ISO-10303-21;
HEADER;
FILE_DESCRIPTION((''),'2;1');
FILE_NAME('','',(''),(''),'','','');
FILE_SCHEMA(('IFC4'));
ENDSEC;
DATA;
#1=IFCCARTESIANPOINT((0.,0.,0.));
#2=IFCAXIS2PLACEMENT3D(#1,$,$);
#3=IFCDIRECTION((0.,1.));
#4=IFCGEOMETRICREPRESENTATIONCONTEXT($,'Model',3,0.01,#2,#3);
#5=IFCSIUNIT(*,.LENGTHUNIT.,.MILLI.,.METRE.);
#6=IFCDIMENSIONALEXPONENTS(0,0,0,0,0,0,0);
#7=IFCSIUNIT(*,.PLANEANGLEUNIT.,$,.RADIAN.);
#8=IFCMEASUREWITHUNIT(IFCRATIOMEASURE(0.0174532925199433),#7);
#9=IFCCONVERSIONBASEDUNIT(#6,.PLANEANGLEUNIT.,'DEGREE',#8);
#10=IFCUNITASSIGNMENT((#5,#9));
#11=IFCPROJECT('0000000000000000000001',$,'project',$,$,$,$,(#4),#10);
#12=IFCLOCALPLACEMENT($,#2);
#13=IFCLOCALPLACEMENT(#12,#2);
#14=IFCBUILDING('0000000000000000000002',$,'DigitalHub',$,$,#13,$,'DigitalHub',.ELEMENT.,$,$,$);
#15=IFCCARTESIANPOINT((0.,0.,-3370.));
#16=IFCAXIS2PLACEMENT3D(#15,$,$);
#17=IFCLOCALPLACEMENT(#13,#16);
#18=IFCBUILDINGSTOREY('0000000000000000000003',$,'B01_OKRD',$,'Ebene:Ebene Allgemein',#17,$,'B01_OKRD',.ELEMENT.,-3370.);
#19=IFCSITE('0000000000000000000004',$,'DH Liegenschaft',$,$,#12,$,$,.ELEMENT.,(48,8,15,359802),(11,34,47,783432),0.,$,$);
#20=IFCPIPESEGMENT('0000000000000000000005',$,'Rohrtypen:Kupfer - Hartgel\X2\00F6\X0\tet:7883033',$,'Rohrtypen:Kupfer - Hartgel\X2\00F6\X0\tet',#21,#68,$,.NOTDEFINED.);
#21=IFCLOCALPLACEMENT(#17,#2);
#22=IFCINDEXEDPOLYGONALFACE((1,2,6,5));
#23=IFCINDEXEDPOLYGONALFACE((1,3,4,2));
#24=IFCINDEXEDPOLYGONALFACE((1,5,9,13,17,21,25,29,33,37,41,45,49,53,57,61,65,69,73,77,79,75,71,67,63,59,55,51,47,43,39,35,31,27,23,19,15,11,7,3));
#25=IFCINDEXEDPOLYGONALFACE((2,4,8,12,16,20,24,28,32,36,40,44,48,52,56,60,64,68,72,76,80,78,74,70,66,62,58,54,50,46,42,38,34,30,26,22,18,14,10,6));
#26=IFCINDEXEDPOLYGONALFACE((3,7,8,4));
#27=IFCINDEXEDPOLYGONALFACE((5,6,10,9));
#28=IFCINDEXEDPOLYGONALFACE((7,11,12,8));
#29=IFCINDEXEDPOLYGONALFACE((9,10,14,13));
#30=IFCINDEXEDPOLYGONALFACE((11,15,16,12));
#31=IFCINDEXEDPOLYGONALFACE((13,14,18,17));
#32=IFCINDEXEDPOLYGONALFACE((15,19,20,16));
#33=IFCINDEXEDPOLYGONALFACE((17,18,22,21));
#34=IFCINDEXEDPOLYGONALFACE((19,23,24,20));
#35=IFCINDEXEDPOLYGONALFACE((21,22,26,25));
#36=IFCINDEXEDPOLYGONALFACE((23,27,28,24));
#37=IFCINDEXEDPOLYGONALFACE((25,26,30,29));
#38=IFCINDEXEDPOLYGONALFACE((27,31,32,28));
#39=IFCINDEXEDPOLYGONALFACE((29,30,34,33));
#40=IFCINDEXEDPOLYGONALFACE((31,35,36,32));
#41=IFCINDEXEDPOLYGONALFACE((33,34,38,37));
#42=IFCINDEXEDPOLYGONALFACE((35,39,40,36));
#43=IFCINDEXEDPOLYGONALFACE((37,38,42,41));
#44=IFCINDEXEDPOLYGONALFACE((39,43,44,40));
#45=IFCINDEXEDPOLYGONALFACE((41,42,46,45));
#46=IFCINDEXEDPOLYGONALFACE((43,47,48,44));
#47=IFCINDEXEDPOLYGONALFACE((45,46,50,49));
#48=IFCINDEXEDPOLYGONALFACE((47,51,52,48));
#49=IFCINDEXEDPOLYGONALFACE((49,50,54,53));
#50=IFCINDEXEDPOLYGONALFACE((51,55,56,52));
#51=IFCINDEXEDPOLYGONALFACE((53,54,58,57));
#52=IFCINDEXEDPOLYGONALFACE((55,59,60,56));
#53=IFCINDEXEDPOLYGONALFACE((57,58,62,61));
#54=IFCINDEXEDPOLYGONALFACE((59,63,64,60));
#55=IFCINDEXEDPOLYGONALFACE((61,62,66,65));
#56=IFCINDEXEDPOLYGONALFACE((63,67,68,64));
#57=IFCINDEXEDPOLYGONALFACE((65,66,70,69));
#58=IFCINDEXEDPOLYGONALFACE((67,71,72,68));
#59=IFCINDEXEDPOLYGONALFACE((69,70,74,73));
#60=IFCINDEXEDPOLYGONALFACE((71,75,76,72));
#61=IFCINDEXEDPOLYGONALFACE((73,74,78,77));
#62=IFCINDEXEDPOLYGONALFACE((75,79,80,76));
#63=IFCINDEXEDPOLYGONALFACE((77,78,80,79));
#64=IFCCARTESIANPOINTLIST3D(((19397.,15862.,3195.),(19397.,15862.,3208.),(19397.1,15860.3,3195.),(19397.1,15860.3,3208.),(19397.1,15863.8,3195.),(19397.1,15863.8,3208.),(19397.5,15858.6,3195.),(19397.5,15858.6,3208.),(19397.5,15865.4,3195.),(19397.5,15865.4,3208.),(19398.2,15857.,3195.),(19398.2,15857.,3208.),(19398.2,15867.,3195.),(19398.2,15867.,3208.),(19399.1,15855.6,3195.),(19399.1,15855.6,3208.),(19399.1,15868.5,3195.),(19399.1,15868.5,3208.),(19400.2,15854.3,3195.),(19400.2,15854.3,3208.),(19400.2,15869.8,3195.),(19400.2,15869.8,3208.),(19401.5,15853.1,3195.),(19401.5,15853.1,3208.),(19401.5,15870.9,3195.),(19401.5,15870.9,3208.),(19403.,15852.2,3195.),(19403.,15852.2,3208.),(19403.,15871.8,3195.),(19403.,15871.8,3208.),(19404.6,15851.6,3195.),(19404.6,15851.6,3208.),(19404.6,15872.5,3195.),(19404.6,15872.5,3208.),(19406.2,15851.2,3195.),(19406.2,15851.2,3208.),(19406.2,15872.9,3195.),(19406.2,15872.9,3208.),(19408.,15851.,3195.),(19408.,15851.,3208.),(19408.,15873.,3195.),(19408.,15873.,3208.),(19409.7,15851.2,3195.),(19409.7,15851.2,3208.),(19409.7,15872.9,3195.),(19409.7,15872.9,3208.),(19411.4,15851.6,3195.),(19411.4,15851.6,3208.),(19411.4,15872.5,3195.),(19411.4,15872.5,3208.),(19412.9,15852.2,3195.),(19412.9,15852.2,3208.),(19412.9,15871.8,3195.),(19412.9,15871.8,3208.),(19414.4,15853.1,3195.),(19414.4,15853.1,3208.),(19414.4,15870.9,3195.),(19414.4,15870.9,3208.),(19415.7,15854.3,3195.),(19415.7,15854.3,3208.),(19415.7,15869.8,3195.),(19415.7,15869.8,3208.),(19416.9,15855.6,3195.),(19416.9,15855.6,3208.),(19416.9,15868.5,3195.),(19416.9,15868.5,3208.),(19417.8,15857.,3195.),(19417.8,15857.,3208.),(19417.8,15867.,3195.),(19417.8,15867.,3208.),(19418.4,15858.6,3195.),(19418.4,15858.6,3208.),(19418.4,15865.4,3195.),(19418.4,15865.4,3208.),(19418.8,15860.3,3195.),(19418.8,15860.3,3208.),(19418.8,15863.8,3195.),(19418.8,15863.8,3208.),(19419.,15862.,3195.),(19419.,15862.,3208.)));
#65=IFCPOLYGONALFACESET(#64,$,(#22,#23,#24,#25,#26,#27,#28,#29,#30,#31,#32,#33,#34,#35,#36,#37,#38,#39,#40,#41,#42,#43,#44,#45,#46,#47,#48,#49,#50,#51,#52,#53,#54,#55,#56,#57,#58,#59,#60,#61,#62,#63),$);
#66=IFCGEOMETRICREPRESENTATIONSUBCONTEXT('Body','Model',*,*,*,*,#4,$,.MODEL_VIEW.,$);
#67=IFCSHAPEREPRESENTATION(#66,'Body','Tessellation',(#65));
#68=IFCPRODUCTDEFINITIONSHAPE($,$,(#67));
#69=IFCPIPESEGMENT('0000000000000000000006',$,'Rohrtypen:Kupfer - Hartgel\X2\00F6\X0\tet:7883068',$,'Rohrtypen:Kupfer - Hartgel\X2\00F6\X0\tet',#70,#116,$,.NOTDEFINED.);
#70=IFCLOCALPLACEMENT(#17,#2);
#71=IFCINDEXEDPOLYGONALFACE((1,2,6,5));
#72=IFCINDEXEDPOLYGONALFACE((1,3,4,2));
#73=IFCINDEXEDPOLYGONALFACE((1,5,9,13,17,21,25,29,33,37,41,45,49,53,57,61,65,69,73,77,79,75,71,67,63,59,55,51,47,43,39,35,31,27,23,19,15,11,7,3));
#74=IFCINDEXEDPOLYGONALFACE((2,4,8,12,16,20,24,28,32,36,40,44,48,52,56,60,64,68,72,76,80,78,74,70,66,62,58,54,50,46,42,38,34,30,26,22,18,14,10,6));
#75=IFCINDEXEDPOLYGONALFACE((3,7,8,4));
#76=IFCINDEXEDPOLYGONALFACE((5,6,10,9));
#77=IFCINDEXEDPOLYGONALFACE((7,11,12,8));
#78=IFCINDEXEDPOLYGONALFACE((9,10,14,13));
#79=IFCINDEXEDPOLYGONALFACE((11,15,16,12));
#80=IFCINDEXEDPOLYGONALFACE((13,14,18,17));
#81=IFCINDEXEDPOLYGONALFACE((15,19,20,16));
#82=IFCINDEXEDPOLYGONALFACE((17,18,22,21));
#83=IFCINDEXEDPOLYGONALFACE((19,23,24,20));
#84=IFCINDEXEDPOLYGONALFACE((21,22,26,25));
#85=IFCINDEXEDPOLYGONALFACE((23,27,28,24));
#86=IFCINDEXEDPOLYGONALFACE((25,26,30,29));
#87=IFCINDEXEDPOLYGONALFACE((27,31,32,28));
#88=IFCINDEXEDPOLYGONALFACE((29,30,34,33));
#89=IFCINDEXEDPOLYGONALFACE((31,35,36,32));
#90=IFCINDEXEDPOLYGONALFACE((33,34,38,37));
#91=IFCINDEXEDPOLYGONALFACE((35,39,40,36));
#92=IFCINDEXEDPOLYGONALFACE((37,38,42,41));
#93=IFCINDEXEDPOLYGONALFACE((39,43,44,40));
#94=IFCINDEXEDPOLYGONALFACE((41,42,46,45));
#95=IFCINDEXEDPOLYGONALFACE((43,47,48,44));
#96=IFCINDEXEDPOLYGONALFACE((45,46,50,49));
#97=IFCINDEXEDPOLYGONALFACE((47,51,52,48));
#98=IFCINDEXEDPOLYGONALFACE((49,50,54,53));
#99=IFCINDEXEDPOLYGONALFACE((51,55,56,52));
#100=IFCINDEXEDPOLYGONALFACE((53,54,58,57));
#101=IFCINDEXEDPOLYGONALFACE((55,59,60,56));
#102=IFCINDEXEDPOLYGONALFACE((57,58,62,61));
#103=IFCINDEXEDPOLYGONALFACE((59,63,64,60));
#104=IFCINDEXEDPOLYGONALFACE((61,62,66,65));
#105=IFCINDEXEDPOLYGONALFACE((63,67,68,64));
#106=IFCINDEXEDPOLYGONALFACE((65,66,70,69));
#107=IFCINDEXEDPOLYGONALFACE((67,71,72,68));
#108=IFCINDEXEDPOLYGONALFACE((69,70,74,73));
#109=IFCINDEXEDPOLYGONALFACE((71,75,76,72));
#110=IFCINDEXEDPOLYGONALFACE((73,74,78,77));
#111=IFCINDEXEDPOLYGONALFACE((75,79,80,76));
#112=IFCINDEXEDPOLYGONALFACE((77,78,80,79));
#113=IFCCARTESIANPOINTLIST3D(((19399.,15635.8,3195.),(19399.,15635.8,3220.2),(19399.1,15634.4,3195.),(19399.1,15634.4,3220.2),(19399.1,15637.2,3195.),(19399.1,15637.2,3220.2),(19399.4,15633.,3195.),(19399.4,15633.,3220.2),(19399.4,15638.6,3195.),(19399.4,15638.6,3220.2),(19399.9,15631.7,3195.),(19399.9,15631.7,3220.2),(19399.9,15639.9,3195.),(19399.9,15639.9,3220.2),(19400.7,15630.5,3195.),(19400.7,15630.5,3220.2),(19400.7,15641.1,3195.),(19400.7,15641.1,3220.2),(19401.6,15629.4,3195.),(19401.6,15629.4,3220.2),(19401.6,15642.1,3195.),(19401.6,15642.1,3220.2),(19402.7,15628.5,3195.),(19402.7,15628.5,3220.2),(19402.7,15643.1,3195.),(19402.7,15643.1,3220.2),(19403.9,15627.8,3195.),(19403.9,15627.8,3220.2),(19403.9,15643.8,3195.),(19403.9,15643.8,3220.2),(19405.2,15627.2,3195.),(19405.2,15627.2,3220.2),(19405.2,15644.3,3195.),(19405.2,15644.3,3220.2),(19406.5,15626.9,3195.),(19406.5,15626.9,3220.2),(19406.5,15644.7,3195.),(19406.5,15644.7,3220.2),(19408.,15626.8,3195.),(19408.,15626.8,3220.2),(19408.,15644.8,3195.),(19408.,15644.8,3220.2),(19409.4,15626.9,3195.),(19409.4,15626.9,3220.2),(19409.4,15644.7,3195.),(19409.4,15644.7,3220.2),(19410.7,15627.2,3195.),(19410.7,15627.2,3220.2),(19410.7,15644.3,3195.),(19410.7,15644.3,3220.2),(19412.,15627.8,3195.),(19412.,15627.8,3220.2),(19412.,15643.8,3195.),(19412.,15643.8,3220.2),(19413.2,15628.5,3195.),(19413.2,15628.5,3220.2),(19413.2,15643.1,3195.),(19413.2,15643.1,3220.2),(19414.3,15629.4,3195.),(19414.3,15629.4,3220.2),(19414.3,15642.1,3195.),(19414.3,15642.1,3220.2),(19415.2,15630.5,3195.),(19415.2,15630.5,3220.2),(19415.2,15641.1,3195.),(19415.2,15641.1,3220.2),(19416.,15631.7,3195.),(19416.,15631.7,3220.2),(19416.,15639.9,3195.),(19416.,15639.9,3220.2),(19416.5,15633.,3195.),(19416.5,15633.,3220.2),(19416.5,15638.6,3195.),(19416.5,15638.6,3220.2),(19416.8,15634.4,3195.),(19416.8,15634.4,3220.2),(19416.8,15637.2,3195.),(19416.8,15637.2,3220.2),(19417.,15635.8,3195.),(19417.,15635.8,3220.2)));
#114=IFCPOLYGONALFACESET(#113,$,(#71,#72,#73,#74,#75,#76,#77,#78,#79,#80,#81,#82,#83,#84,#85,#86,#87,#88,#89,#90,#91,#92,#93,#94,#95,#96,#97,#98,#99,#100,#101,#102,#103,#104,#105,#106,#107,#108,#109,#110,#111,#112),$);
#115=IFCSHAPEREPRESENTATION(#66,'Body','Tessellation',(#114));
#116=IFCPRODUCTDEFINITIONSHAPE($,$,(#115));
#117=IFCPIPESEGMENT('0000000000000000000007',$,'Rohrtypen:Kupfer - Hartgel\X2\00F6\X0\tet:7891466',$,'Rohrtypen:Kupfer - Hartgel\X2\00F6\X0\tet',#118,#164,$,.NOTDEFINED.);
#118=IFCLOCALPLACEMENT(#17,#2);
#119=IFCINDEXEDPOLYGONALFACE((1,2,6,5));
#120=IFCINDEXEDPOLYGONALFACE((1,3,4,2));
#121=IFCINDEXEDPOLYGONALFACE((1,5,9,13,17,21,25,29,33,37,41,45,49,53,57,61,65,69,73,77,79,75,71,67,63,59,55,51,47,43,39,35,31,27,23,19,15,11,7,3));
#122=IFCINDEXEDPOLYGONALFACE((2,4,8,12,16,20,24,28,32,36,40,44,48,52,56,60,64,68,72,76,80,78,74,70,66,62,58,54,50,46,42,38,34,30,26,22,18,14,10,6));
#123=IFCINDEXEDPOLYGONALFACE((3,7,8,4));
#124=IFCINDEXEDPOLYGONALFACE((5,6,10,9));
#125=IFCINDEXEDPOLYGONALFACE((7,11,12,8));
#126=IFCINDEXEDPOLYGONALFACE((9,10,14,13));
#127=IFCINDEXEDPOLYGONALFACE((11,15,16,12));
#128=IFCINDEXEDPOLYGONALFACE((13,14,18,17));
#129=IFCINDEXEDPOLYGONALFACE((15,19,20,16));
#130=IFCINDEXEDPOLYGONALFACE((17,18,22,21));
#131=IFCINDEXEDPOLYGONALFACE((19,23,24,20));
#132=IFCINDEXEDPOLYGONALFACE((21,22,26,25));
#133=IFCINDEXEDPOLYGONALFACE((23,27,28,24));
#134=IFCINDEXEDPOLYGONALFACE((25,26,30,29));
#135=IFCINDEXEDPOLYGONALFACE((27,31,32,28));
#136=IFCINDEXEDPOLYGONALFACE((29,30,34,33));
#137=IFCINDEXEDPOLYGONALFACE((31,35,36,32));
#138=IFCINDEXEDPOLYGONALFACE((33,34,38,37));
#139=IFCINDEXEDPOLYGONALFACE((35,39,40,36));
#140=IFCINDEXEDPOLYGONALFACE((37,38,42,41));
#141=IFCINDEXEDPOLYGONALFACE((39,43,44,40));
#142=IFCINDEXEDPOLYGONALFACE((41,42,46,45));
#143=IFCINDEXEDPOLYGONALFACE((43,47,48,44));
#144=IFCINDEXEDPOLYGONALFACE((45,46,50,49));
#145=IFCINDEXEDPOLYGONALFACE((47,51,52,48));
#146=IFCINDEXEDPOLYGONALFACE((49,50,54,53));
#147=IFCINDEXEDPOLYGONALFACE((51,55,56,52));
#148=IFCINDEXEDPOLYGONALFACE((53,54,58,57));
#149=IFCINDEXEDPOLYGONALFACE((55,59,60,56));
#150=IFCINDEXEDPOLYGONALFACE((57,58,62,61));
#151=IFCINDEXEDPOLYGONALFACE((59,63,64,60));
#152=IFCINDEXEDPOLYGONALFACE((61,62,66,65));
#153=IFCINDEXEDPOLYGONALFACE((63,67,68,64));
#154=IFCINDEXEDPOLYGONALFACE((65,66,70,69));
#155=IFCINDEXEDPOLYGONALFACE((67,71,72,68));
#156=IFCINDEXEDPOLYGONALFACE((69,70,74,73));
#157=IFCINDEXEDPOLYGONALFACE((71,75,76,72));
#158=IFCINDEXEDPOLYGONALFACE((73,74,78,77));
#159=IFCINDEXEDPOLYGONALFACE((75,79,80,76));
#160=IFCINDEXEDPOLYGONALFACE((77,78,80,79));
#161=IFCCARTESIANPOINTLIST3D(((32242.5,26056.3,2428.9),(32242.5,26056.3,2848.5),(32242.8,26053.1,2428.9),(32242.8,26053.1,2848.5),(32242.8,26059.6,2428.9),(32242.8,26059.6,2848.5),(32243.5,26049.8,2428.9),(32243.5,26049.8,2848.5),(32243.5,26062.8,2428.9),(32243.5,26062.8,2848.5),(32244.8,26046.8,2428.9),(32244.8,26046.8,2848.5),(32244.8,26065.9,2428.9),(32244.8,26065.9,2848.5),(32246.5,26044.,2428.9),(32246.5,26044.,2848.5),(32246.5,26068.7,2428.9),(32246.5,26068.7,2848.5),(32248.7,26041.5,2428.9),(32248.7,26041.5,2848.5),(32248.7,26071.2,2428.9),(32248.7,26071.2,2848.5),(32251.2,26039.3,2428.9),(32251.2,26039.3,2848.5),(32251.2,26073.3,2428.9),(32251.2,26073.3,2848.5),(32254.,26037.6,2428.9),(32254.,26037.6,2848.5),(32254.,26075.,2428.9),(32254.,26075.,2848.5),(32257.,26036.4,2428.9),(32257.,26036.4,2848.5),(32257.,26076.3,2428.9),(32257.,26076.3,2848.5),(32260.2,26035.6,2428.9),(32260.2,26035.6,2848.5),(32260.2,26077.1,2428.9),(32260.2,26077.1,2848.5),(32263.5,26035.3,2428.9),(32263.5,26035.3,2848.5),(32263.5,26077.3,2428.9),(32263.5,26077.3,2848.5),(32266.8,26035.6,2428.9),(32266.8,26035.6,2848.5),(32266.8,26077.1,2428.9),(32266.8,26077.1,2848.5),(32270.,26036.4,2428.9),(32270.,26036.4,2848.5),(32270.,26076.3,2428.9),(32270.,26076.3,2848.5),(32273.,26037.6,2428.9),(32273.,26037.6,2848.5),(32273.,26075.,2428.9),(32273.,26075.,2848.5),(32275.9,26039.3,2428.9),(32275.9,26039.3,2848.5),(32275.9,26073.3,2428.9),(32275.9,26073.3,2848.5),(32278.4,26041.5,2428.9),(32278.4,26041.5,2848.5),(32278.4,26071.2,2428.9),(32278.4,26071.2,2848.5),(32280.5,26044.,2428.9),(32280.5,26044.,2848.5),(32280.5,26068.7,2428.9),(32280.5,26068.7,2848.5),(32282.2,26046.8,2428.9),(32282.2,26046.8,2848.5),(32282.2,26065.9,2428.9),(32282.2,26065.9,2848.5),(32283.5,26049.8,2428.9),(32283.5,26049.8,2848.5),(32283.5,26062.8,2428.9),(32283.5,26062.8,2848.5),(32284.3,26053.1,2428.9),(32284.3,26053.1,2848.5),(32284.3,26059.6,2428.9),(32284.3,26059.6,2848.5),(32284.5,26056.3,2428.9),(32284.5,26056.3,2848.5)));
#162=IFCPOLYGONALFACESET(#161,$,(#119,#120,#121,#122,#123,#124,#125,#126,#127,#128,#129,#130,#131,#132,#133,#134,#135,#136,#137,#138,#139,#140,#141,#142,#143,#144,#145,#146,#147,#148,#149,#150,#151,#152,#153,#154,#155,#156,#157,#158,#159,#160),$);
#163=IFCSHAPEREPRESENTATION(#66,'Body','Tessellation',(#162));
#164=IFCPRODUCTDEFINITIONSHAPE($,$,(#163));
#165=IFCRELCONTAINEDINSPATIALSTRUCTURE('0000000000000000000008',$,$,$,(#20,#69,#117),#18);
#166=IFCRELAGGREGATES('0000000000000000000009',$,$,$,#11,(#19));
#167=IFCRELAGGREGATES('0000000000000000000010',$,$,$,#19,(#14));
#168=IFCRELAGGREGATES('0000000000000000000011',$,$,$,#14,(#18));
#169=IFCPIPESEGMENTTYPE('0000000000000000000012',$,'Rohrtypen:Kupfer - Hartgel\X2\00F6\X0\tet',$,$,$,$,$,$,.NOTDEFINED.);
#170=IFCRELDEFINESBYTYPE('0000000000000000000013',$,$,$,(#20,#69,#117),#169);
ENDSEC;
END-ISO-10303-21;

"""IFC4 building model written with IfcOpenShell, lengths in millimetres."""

from ifc_helpers import new_model, entity, si_unit, converted_unit, direction, frame, origin, place, context, subcontext, project, spatial, indexed_curve, outline, extrude, type_object, element, save


model = new_model("IFC4")

# Units and contexts
model_context = context("Model", 3, precision=0.01, world=origin(), true_north=direction((0.0, 1.0)))
body_context = subcontext(model_context, "Body", "Model", "MODEL_VIEW")
ifc_project = project(units=[si_unit("LENGTHUNIT", "METRE", prefix="MILLI"), converted_unit("PLANEANGLEUNIT", "DEGREE", entity("IfcRatioMeasure", 0.0174532925199433), si_unit("PLANEANGLEUNIT", "RADIAN"), dimensions=[0, 0, 0, 0, 0, 0, 0])], contexts=[model_context])

# Site, building, storey
site_placement = place(None, origin())
site = spatial("IfcSite", under=ifc_project, at=site_placement, Name="DH Liegenschaft", CompositionType="ELEMENT", RefLatitude=(48, 8, 15, 359802), RefLongitude=(11, 34, 47, 783432), RefElevation=0.0)
building_placement = place(site_placement, origin())
building = spatial("IfcBuilding", under=site, at=building_placement, Name="DigitalHub", LongName="DigitalHub", CompositionType="ELEMENT")
storey_placement = place(building_placement, frame((0.0, 0.0, -3370.0)))
storey = spatial("IfcBuildingStorey", under=building, at=storey_placement, Name="B01_OKRD", ObjectType="Ebene:Ebene Allgemein", LongName="B01_OKRD", CompositionType="ELEMENT", Elevation=-3370.0)

# Pipe segments
pipe_segment_type = type_object("IfcPipeSegmentType", Name="Rohrtypen:Kupfer - Hartgelötet", PredefinedType="NOTDEFINED")
pipe_segment_1_placement = place(storey_placement, frame((19395.4, 15849.4, 3195.0)))
element("IfcPipeSegment", 1, at=pipe_segment_1_placement, inside=storey, type_object=pipe_segment_type, Name="Rohrtypen:Kupfer - Hartgelötet:7883033", ObjectType="Rohrtypen:Kupfer - Hartgelötet", PredefinedType="NOTDEFINED", context=body_context, shape_type="SweptSolid", body=[
    extrude(outline(indexed_curve([(11.0, 0.0), (10.9, 1.7), (10.5, 3.4), (9.8, 5.0), (8.9, 6.5), (7.8, 7.8), (6.5, 8.9), (5.0, 9.8), (3.4, 10.5), (1.7, 10.9), (0.0, 11.0), (-1.7, 10.9), (-3.4, 10.5), (-5.0, 9.8), (-6.5, 8.9), (-7.8, 7.8), (-8.9, 6.5), (-9.8, 5.0), (-10.5, 3.4), (-10.9, 1.7), (-11.0, 0.0), (-10.9, -1.7), (-10.5, -3.4), (-9.8, -5.0), (-8.9, -6.5), (-7.8, -7.8), (-6.5, -8.9), (-5.0, -9.8), (-3.4, -10.5), (-1.7, -10.9), (0.0, -11.0), (1.7, -10.9), (3.4, -10.5), (5.0, -9.8), (6.5, -8.9), (7.8, -7.8), (8.9, -6.5), (9.8, -5.0), (10.5, -3.4), (10.9, -1.7), (11.0, 0.0)], self_intersect=False)), frame((12.6, 12.6, 0.0)), (0.0, 0.0, 1.0), 13.0),
])
pipe_segment_2_placement = place(storey_placement, frame((19397.4, 15625.2, 3195.0)))
element("IfcPipeSegment", 2, at=pipe_segment_2_placement, inside=storey, type_object=pipe_segment_type, Name="Rohrtypen:Kupfer - Hartgelötet:7883068", ObjectType="Rohrtypen:Kupfer - Hartgelötet", PredefinedType="NOTDEFINED", context=body_context, shape_type="SweptSolid", body=[
    extrude(outline(indexed_curve([(9.0, 0.0), (8.9, 1.4), (8.6, 2.8), (8.0, 4.1), (7.3, 5.3), (6.4, 6.4), (5.3, 7.3), (4.1, 8.0), (2.8, 8.6), (1.4, 8.9), (0.0, 9.0), (-1.4, 8.9), (-2.8, 8.6), (-4.1, 8.0), (-5.3, 7.3), (-6.4, 6.4), (-7.3, 5.3), (-8.0, 4.1), (-8.6, 2.8), (-8.9, 1.4), (-9.0, 0.0), (-8.9, -1.4), (-8.6, -2.8), (-8.0, -4.1), (-7.3, -5.3), (-6.4, -6.4), (-5.3, -7.3), (-4.1, -8.0), (-2.8, -8.6), (-1.4, -8.9), (0.0, -9.0), (1.4, -8.9), (2.8, -8.6), (4.1, -8.0), (5.3, -7.3), (6.4, -6.4), (7.3, -5.3), (8.0, -4.1), (8.6, -2.8), (8.9, -1.4), (9.0, 0.0)], self_intersect=False)), frame((10.6, 10.6, 0.0)), (0.0, 0.0, 1.0), 25.2),
])
pipe_segment_3_placement = place(storey_placement, frame((32240.9, 26033.7, 2428.9)))
element("IfcPipeSegment", 3, at=pipe_segment_3_placement, inside=storey, type_object=pipe_segment_type, Name="Rohrtypen:Kupfer - Hartgelötet:7891466", ObjectType="Rohrtypen:Kupfer - Hartgelötet", PredefinedType="NOTDEFINED", context=body_context, shape_type="SweptSolid", body=[
    extrude(outline(indexed_curve([(21.0, 0.0), (20.7, 3.3), (20.0, 6.5), (18.7, 9.5), (17.0, 12.3), (14.8, 14.8), (12.3, 17.0), (9.5, 18.7), (6.5, 20.0), (3.3, 20.7), (0.0, 21.0), (-3.3, 20.7), (-6.5, 20.0), (-9.5, 18.7), (-12.3, 17.0), (-14.8, 14.8), (-17.0, 12.3), (-18.7, 9.5), (-20.0, 6.5), (-20.7, 3.3), (-21.0, 0.0), (-20.7, -3.3), (-20.0, -6.5), (-18.7, -9.5), (-17.0, -12.3), (-14.8, -14.8), (-12.3, -17.0), (-9.5, -18.7), (-6.5, -20.0), (-3.3, -20.7), (0.0, -21.0), (3.3, -20.7), (6.5, -20.0), (9.5, -18.7), (12.3, -17.0), (14.8, -14.8), (17.0, -12.3), (18.7, -9.5), (20.0, -6.5), (20.7, -3.3), (21.0, 0.0)], self_intersect=False)), frame((22.6, 22.6, 0.0), z_axis=(0.0, 0.0, 1.0), x_axis=(-1.0, 0.0, 0.0)), (0.0, 0.0, 1.0), 419.6),
])

save(model, "model.ifc")
